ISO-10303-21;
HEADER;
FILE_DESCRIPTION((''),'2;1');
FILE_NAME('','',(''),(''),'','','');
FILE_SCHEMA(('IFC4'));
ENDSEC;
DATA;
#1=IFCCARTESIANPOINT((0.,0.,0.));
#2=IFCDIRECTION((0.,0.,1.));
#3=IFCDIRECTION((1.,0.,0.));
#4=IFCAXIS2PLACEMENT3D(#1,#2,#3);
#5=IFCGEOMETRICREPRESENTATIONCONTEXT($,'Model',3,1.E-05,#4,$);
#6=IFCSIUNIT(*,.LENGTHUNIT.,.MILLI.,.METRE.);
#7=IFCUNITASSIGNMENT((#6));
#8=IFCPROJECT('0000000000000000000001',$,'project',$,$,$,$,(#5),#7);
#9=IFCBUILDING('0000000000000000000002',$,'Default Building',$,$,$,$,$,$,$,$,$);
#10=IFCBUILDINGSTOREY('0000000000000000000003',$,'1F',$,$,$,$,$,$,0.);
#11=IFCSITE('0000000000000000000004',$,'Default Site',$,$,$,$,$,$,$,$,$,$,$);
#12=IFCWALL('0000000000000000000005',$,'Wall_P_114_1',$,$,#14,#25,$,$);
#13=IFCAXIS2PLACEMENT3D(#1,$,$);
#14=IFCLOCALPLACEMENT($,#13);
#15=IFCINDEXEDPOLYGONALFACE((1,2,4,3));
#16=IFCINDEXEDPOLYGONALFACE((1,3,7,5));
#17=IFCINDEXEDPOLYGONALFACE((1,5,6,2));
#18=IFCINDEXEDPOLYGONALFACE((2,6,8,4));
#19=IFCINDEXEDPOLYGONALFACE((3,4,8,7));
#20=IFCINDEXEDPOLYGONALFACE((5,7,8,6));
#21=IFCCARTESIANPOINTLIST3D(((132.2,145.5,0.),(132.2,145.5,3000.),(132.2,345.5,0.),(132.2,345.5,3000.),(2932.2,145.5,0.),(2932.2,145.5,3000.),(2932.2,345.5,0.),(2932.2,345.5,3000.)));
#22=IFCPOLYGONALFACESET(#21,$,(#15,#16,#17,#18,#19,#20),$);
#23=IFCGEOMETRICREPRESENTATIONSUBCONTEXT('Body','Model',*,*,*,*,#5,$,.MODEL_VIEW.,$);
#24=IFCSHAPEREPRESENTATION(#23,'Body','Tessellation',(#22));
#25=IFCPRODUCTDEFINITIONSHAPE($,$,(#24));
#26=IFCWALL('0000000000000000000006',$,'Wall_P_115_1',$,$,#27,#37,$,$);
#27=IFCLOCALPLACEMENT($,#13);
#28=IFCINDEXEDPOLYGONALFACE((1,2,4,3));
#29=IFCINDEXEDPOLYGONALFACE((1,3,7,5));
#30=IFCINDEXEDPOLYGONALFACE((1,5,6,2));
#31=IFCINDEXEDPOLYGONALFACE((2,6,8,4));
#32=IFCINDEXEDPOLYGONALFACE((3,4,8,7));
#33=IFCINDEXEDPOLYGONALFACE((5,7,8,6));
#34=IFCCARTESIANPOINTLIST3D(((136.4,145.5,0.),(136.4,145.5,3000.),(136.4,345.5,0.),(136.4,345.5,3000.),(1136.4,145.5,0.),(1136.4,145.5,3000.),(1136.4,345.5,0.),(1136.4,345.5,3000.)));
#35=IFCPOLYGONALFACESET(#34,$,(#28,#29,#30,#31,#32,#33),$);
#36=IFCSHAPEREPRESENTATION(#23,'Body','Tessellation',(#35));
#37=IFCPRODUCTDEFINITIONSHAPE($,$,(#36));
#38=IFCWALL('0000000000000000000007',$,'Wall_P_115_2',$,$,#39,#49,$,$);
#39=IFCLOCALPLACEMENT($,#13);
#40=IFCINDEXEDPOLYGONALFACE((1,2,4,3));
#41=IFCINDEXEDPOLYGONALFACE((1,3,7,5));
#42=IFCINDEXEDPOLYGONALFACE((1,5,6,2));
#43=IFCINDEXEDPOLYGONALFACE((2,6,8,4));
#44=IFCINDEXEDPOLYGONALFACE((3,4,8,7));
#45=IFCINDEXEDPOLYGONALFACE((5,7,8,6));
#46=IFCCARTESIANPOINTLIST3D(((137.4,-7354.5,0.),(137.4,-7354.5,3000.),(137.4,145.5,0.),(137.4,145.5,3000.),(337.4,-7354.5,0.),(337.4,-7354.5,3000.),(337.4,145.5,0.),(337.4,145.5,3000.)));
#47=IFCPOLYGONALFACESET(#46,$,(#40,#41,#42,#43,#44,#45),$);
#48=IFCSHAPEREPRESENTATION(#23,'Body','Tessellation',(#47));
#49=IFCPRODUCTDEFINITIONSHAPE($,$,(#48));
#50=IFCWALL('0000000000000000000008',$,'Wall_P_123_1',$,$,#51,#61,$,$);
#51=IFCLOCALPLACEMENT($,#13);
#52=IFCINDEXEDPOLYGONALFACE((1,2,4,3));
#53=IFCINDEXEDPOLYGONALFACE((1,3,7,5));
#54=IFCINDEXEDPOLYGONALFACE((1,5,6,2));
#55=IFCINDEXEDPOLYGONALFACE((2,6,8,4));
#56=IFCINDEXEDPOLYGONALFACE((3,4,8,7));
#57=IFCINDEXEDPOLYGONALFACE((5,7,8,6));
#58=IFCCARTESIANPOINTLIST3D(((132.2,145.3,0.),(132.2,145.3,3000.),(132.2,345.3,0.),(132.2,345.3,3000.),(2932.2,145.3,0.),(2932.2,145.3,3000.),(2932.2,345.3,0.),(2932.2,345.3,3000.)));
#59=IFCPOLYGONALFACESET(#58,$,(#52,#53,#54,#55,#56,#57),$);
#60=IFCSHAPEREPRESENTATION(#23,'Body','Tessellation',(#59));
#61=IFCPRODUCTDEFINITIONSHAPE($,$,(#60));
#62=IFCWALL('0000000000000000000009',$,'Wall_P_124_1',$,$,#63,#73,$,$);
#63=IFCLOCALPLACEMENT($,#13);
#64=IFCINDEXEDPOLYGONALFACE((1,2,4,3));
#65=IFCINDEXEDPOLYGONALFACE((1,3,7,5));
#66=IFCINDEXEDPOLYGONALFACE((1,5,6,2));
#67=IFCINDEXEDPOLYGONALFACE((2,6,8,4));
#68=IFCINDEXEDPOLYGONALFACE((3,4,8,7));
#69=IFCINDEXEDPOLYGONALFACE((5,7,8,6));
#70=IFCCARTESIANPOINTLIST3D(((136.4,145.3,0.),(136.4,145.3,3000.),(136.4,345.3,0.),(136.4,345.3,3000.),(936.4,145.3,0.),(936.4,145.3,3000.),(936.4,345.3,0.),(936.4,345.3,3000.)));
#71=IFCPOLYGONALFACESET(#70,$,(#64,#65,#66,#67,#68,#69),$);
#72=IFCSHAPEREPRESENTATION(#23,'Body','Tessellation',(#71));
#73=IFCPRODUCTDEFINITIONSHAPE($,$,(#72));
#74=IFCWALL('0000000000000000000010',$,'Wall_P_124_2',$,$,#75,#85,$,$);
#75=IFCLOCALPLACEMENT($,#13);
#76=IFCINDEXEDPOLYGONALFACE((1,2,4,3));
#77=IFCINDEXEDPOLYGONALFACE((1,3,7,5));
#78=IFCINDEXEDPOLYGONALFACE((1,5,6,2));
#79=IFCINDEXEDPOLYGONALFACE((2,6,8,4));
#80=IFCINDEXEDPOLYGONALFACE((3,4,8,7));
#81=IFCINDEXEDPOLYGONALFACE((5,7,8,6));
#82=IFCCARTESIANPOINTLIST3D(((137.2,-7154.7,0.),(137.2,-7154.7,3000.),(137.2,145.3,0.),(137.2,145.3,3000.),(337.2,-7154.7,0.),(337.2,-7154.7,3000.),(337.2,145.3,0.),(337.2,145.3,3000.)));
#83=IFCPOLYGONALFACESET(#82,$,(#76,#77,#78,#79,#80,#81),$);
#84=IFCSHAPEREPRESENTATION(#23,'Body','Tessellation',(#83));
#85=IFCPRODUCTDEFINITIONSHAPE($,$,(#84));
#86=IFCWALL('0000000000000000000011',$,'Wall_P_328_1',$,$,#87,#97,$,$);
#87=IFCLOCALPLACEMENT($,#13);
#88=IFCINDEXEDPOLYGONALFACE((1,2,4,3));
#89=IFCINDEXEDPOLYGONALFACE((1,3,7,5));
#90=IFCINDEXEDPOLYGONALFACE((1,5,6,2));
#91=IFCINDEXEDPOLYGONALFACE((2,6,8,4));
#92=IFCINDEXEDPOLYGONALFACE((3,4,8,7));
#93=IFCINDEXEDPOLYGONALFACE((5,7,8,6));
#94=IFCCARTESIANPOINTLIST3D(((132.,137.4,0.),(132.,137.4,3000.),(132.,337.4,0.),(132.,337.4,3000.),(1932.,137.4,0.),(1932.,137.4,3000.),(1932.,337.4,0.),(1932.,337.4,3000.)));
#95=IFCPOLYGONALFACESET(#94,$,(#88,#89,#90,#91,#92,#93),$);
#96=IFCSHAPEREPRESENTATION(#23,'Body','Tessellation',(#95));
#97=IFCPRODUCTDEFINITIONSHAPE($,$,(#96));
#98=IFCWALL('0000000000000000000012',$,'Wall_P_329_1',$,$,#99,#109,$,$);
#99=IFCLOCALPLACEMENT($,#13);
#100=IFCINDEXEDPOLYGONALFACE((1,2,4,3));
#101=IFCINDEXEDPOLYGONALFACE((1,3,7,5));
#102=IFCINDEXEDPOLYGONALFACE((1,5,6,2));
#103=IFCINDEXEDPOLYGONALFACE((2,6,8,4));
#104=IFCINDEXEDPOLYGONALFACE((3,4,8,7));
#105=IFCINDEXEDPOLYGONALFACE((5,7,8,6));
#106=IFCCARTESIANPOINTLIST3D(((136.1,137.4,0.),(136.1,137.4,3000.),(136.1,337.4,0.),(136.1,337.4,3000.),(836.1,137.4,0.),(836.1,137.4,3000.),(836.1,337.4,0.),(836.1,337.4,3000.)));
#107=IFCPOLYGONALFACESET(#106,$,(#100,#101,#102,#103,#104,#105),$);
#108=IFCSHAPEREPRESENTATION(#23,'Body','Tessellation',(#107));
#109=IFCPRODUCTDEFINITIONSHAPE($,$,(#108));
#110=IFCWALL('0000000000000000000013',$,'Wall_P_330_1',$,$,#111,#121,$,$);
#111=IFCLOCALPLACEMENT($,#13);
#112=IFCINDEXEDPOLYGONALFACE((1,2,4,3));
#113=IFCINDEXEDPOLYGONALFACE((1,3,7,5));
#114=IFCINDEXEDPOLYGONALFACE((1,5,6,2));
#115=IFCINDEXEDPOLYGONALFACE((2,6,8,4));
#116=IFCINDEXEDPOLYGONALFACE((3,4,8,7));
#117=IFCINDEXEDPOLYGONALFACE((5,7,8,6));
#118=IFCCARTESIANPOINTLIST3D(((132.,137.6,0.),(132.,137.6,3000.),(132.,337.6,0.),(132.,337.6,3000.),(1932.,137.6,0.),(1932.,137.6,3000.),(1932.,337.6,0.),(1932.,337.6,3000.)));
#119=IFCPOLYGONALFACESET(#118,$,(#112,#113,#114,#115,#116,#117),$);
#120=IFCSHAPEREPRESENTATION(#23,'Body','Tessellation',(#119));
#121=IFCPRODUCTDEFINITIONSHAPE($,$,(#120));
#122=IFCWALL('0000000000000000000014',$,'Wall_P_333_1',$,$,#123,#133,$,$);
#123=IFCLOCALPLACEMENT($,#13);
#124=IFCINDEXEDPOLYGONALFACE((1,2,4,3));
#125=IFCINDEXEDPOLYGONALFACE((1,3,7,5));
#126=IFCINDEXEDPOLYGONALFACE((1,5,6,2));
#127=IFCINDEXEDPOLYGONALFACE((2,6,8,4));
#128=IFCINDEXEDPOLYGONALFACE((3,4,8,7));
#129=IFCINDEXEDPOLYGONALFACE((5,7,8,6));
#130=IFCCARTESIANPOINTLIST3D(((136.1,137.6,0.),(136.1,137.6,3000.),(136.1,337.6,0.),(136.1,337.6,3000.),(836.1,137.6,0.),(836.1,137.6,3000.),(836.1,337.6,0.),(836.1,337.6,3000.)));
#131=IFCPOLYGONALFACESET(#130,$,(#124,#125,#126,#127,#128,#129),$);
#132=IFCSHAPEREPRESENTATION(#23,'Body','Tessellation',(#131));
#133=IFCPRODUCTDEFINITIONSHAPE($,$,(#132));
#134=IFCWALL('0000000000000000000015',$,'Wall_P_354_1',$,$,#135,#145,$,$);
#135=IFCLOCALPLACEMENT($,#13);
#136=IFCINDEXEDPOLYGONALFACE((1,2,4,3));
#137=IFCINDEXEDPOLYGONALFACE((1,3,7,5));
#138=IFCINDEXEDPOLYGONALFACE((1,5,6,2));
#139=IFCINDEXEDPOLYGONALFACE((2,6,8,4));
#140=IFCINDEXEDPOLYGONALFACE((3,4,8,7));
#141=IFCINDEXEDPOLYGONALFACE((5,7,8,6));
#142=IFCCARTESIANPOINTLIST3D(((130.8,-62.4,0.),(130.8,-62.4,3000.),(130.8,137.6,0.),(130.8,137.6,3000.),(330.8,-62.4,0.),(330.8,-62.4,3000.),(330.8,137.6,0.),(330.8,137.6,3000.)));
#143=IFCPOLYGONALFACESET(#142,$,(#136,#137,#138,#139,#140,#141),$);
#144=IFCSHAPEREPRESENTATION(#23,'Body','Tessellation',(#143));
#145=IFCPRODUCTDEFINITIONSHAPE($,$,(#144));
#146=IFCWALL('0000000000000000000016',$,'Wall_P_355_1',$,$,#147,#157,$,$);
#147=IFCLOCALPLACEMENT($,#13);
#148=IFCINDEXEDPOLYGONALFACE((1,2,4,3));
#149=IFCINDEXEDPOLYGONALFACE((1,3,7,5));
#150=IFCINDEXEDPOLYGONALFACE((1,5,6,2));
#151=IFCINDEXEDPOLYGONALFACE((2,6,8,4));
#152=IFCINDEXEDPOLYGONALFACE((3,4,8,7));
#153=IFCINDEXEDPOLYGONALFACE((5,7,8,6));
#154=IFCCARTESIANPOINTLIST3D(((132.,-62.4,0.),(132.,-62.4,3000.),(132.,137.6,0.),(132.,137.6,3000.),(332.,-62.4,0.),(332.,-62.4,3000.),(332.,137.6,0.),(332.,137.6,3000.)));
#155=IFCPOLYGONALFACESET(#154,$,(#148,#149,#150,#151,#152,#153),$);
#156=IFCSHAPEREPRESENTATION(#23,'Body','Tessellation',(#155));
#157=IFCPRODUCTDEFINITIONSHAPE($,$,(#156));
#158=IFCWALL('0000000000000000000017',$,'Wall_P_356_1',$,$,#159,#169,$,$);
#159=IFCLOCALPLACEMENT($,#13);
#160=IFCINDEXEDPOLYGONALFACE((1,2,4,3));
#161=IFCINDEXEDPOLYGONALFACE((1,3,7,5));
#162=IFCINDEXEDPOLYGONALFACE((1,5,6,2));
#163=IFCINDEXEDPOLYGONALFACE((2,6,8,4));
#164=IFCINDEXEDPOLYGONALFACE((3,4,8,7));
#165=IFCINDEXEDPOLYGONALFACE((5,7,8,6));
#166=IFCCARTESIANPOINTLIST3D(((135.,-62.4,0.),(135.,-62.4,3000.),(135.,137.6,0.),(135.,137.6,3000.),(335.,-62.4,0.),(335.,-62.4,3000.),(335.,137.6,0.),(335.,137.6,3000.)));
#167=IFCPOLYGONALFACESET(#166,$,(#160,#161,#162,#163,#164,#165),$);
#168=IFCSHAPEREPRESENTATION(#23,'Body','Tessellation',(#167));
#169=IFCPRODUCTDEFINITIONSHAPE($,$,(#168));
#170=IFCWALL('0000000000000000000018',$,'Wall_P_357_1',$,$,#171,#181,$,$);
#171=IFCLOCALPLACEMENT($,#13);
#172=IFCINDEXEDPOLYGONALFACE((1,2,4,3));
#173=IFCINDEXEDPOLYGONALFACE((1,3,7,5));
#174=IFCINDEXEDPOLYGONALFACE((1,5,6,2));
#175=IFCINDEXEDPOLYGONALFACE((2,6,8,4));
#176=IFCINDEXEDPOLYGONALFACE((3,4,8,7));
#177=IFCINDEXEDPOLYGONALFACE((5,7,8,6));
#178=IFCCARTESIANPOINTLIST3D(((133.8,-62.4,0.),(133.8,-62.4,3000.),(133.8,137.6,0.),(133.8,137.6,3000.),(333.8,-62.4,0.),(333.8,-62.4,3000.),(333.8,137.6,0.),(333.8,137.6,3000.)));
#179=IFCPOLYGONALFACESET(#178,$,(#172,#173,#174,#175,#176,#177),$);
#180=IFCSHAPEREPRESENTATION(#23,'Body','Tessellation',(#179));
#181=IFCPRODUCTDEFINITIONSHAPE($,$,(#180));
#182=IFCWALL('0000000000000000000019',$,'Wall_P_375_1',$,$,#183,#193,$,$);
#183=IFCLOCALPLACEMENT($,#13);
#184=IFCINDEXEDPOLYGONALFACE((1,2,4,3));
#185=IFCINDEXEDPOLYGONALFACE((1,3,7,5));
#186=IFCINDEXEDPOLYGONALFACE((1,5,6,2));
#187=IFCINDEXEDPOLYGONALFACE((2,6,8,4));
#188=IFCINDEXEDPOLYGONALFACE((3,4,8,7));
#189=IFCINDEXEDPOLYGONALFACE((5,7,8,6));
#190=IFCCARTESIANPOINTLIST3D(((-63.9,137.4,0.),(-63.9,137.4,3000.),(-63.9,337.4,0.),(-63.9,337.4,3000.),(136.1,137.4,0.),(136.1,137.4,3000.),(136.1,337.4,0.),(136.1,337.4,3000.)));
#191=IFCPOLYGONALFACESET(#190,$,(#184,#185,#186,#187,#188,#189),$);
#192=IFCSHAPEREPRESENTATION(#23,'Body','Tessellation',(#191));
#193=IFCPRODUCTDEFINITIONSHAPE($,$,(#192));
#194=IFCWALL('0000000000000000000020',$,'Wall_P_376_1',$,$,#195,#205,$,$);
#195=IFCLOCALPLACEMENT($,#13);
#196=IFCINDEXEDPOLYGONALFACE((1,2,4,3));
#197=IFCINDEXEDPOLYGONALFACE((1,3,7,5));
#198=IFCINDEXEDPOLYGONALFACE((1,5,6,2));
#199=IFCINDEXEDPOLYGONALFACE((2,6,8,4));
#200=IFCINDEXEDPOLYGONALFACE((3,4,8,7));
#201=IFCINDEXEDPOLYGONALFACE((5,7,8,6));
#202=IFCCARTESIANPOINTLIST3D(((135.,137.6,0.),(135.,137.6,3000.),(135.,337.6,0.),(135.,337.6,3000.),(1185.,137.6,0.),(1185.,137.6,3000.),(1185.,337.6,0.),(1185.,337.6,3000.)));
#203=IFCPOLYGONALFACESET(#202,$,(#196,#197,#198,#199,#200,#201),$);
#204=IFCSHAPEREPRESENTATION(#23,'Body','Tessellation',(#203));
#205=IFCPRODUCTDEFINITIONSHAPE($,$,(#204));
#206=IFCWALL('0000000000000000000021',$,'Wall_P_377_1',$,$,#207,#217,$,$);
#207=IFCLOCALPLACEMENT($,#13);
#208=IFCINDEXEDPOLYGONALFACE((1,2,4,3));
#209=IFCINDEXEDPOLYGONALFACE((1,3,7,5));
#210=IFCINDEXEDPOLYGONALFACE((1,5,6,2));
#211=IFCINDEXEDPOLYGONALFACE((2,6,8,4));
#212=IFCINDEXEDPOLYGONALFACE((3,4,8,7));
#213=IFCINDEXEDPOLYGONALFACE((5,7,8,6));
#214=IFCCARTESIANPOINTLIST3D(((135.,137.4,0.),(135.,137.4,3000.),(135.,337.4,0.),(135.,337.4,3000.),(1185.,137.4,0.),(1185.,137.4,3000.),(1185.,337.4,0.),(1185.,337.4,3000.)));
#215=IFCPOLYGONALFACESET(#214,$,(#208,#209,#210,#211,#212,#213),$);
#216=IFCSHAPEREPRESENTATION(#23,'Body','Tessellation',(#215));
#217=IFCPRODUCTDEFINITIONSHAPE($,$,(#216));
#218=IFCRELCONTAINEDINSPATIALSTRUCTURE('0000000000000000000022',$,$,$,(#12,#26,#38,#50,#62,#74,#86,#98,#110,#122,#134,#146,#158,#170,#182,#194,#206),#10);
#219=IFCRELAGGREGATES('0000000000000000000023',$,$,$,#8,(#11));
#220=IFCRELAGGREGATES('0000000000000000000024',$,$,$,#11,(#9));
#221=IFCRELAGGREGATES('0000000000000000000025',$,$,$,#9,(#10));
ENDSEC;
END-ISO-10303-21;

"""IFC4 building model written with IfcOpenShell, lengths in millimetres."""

from ifc_helpers import new_model, si_unit, frame, origin_with_axes, place, context, subcontext, project, spatial, indexed_curve, outline, extrude, element, save


model = new_model("IFC4")

# Units and contexts
model_context = context("Model", 3, precision=1e-05, world=origin_with_axes())
body_context = subcontext(model_context, "Body", "Model", "MODEL_VIEW")
ifc_project = project(units=[si_unit("LENGTHUNIT", "METRE", prefix="MILLI")], contexts=[model_context])

# Site, building, storey
site = spatial("IfcSite", under=ifc_project, Name="Default Site")
building = spatial("IfcBuilding", under=site, Name="Default Building")
storey = spatial("IfcBuildingStorey", under=building, Name="1F", Elevation=0.0)

# Walls
wall_1_placement = place(None, frame((132.2, 145.5, 0.0), z_axis=(0.0, 0.0, 1.0), x_axis=(1.0, 0.0, 0.0)))
element("IfcWall", 1, at=wall_1_placement, inside=storey, Name="Wall_P_114_1", context=body_context, shape_type="SweptSolid", body=[
    extrude(outline(indexed_curve([(0.0, 0.0), (0.0, 200.0), (2800.0, 200.0), (2800.0, 0.0), (0.0, 0.0)], self_intersect=False)), origin_with_axes(), (0.0, 0.0, 1.0), 3000.0),
])
wall_2_placement = place(None, frame((136.4, 145.5, 0.0), z_axis=(0.0, 0.0, 1.0), x_axis=(1.0, 0.0, 0.0)))
element("IfcWall", 2, at=wall_2_placement, inside=storey, Name="Wall_P_115_1", context=body_context, shape_type="SweptSolid", body=[
    extrude(outline(indexed_curve([(0.0, 0.0), (0.0, 200.0), (1000.0, 200.0), (1000.0, 0.0), (0.0, 0.0)], self_intersect=False)), origin_with_axes(), (0.0, 0.0, 1.0), 3000.0),
])
wall_3_placement = place(None, frame((137.4, 145.5, 0.0), z_axis=(0.0, 0.0, 1.0), x_axis=(0.0, -1.0, 0.0)))
element("IfcWall", 3, at=wall_3_placement, inside=storey, Name="Wall_P_115_2", context=body_context, shape_type="SweptSolid", body=[
    extrude(outline(indexed_curve([(0.0, 0.0), (0.0, 200.0), (7500.0, 200.0), (7500.0, 0.0), (0.0, 0.0)], self_intersect=False)), origin_with_axes(), (0.0, 0.0, 1.0), 3000.0),
])
wall_4_placement = place(None, frame((132.2, 145.3, 0.0), z_axis=(0.0, 0.0, 1.0), x_axis=(1.0, 0.0, 0.0)))
element("IfcWall", 4, at=wall_4_placement, inside=storey, Name="Wall_P_123_1", context=body_context, shape_type="SweptSolid", body=[
    extrude(outline(indexed_curve([(0.0, 0.0), (0.0, 200.0), (2800.0, 200.0), (2800.0, 0.0), (0.0, 0.0)], self_intersect=False)), origin_with_axes(), (0.0, 0.0, 1.0), 3000.0),
])
wall_5_placement = place(None, frame((136.4, 145.3, 0.0), z_axis=(0.0, 0.0, 1.0), x_axis=(1.0, 0.0, 0.0)))
element("IfcWall", 5, at=wall_5_placement, inside=storey, Name="Wall_P_124_1", context=body_context, shape_type="SweptSolid", body=[
    extrude(outline(indexed_curve([(0.0, 0.0), (0.0, 200.0), (800.0, 200.0), (800.0, 0.0), (0.0, 0.0)], self_intersect=False)), origin_with_axes(), (0.0, 0.0, 1.0), 3000.0),
])
wall_6_placement = place(None, frame((137.2, 145.3, 0.0), z_axis=(0.0, 0.0, 1.0), x_axis=(0.0, -1.0, 0.0)))
element("IfcWall", 6, at=wall_6_placement, inside=storey, Name="Wall_P_124_2", context=body_context, shape_type="SweptSolid", body=[
    extrude(outline(indexed_curve([(0.0, 0.0), (0.0, 200.0), (7300.0, 200.0), (7300.0, 0.0), (0.0, 0.0)], self_intersect=False)), origin_with_axes(), (0.0, 0.0, 1.0), 3000.0),
])
wall_7_placement = place(None, frame((132.0, 137.4, 0.0), z_axis=(0.0, 0.0, 1.0), x_axis=(1.0, 0.0, 0.0)))
element("IfcWall", 7, at=wall_7_placement, inside=storey, Name="Wall_P_328_1", context=body_context, shape_type="SweptSolid", body=[
    extrude(outline(indexed_curve([(0.0, 0.0), (0.0, 200.0), (1800.0, 200.0), (1800.0, 0.0), (0.0, 0.0)], self_intersect=False)), origin_with_axes(), (0.0, 0.0, 1.0), 3000.0),
])
wall_8_placement = place(None, frame((136.1, 137.4, 0.0), z_axis=(0.0, 0.0, 1.0), x_axis=(1.0, 0.0, 0.0)))
element("IfcWall", 8, at=wall_8_placement, inside=storey, Name="Wall_P_329_1", context=body_context, shape_type="SweptSolid", body=[
    extrude(outline(indexed_curve([(0.0, 0.0), (0.0, 200.0), (700.0, 200.0), (700.0, 0.0), (0.0, 0.0)], self_intersect=False)), origin_with_axes(), (0.0, 0.0, 1.0), 3000.0),
])
wall_9_placement = place(None, frame((132.0, 137.6, 0.0), z_axis=(0.0, 0.0, 1.0), x_axis=(1.0, 0.0, 0.0)))
element("IfcWall", 9, at=wall_9_placement, inside=storey, Name="Wall_P_330_1", context=body_context, shape_type="SweptSolid", body=[
    extrude(outline(indexed_curve([(0.0, 0.0), (0.0, 200.0), (1800.0, 200.0), (1800.0, 0.0), (0.0, 0.0)], self_intersect=False)), origin_with_axes(), (0.0, 0.0, 1.0), 3000.0),
])
wall_10_placement = place(None, frame((136.1, 137.6, 0.0), z_axis=(0.0, 0.0, 1.0), x_axis=(1.0, 0.0, 0.0)))
element("IfcWall", 10, at=wall_10_placement, inside=storey, Name="Wall_P_333_1", context=body_context, shape_type="SweptSolid", body=[
    extrude(outline(indexed_curve([(0.0, 0.0), (0.0, 200.0), (700.0, 200.0), (700.0, 0.0), (0.0, 0.0)], self_intersect=False)), origin_with_axes(), (0.0, 0.0, 1.0), 3000.0),
])
for number, where, z_axis, x_axis, name in (
    (11, (130.8, 137.6, 0.0), (0.0, 0.0, 1.0), (0.0, -1.0, 0.0), "Wall_P_354_1"),
    (12, (132.0, 137.6, 0.0), (0.0, 0.0, 1.0), (0.0, -1.0, 0.0), "Wall_P_355_1"),
    (13, (135.0, 137.6, 0.0), (0.0, 0.0, 1.0), (0.0, -1.0, 0.0), "Wall_P_356_1"),
    (14, (133.8, 137.6, 0.0), (0.0, 0.0, 1.0), (0.0, -1.0, 0.0), "Wall_P_357_1"),
    (15, (136.1, 137.4, 0.0), (0.0, 0.0, 1.0), (0.0, 1.0, 0.0), "Wall_P_375_1"),
):
    element("IfcWall", number, at=place(None, frame(where, z_axis=z_axis, x_axis=x_axis)), inside=storey, Name=name, context=body_context, shape_type="SweptSolid", body=[
        extrude(outline(indexed_curve([(0.0, 0.0), (0.0, 200.0), (200.0, 200.0), (200.0, 0.0), (0.0, 0.0)], self_intersect=False)), origin_with_axes(), (0.0, 0.0, 1.0), 3000.0),
    ])
for number, where, z_axis, x_axis, name in (
    (16, (135.0, 137.6, 0.0), (0.0, 0.0, 1.0), (1.0, 0.0, 0.0), "Wall_P_376_1"),
    (17, (135.0, 137.4, 0.0), (0.0, 0.0, 1.0), (1.0, 0.0, 0.0), "Wall_P_377_1"),
):
    element("IfcWall", number, at=place(None, frame(where, z_axis=z_axis, x_axis=x_axis)), inside=storey, Name=name, context=body_context, shape_type="SweptSolid", body=[
        extrude(outline(indexed_curve([(0.0, 0.0), (0.0, 200.0), (1050.0, 200.0), (1050.0, 0.0), (0.0, 0.0)], self_intersect=False)), origin_with_axes(), (0.0, 0.0, 1.0), 3000.0),
    ])

save(model, "model.ifc")
